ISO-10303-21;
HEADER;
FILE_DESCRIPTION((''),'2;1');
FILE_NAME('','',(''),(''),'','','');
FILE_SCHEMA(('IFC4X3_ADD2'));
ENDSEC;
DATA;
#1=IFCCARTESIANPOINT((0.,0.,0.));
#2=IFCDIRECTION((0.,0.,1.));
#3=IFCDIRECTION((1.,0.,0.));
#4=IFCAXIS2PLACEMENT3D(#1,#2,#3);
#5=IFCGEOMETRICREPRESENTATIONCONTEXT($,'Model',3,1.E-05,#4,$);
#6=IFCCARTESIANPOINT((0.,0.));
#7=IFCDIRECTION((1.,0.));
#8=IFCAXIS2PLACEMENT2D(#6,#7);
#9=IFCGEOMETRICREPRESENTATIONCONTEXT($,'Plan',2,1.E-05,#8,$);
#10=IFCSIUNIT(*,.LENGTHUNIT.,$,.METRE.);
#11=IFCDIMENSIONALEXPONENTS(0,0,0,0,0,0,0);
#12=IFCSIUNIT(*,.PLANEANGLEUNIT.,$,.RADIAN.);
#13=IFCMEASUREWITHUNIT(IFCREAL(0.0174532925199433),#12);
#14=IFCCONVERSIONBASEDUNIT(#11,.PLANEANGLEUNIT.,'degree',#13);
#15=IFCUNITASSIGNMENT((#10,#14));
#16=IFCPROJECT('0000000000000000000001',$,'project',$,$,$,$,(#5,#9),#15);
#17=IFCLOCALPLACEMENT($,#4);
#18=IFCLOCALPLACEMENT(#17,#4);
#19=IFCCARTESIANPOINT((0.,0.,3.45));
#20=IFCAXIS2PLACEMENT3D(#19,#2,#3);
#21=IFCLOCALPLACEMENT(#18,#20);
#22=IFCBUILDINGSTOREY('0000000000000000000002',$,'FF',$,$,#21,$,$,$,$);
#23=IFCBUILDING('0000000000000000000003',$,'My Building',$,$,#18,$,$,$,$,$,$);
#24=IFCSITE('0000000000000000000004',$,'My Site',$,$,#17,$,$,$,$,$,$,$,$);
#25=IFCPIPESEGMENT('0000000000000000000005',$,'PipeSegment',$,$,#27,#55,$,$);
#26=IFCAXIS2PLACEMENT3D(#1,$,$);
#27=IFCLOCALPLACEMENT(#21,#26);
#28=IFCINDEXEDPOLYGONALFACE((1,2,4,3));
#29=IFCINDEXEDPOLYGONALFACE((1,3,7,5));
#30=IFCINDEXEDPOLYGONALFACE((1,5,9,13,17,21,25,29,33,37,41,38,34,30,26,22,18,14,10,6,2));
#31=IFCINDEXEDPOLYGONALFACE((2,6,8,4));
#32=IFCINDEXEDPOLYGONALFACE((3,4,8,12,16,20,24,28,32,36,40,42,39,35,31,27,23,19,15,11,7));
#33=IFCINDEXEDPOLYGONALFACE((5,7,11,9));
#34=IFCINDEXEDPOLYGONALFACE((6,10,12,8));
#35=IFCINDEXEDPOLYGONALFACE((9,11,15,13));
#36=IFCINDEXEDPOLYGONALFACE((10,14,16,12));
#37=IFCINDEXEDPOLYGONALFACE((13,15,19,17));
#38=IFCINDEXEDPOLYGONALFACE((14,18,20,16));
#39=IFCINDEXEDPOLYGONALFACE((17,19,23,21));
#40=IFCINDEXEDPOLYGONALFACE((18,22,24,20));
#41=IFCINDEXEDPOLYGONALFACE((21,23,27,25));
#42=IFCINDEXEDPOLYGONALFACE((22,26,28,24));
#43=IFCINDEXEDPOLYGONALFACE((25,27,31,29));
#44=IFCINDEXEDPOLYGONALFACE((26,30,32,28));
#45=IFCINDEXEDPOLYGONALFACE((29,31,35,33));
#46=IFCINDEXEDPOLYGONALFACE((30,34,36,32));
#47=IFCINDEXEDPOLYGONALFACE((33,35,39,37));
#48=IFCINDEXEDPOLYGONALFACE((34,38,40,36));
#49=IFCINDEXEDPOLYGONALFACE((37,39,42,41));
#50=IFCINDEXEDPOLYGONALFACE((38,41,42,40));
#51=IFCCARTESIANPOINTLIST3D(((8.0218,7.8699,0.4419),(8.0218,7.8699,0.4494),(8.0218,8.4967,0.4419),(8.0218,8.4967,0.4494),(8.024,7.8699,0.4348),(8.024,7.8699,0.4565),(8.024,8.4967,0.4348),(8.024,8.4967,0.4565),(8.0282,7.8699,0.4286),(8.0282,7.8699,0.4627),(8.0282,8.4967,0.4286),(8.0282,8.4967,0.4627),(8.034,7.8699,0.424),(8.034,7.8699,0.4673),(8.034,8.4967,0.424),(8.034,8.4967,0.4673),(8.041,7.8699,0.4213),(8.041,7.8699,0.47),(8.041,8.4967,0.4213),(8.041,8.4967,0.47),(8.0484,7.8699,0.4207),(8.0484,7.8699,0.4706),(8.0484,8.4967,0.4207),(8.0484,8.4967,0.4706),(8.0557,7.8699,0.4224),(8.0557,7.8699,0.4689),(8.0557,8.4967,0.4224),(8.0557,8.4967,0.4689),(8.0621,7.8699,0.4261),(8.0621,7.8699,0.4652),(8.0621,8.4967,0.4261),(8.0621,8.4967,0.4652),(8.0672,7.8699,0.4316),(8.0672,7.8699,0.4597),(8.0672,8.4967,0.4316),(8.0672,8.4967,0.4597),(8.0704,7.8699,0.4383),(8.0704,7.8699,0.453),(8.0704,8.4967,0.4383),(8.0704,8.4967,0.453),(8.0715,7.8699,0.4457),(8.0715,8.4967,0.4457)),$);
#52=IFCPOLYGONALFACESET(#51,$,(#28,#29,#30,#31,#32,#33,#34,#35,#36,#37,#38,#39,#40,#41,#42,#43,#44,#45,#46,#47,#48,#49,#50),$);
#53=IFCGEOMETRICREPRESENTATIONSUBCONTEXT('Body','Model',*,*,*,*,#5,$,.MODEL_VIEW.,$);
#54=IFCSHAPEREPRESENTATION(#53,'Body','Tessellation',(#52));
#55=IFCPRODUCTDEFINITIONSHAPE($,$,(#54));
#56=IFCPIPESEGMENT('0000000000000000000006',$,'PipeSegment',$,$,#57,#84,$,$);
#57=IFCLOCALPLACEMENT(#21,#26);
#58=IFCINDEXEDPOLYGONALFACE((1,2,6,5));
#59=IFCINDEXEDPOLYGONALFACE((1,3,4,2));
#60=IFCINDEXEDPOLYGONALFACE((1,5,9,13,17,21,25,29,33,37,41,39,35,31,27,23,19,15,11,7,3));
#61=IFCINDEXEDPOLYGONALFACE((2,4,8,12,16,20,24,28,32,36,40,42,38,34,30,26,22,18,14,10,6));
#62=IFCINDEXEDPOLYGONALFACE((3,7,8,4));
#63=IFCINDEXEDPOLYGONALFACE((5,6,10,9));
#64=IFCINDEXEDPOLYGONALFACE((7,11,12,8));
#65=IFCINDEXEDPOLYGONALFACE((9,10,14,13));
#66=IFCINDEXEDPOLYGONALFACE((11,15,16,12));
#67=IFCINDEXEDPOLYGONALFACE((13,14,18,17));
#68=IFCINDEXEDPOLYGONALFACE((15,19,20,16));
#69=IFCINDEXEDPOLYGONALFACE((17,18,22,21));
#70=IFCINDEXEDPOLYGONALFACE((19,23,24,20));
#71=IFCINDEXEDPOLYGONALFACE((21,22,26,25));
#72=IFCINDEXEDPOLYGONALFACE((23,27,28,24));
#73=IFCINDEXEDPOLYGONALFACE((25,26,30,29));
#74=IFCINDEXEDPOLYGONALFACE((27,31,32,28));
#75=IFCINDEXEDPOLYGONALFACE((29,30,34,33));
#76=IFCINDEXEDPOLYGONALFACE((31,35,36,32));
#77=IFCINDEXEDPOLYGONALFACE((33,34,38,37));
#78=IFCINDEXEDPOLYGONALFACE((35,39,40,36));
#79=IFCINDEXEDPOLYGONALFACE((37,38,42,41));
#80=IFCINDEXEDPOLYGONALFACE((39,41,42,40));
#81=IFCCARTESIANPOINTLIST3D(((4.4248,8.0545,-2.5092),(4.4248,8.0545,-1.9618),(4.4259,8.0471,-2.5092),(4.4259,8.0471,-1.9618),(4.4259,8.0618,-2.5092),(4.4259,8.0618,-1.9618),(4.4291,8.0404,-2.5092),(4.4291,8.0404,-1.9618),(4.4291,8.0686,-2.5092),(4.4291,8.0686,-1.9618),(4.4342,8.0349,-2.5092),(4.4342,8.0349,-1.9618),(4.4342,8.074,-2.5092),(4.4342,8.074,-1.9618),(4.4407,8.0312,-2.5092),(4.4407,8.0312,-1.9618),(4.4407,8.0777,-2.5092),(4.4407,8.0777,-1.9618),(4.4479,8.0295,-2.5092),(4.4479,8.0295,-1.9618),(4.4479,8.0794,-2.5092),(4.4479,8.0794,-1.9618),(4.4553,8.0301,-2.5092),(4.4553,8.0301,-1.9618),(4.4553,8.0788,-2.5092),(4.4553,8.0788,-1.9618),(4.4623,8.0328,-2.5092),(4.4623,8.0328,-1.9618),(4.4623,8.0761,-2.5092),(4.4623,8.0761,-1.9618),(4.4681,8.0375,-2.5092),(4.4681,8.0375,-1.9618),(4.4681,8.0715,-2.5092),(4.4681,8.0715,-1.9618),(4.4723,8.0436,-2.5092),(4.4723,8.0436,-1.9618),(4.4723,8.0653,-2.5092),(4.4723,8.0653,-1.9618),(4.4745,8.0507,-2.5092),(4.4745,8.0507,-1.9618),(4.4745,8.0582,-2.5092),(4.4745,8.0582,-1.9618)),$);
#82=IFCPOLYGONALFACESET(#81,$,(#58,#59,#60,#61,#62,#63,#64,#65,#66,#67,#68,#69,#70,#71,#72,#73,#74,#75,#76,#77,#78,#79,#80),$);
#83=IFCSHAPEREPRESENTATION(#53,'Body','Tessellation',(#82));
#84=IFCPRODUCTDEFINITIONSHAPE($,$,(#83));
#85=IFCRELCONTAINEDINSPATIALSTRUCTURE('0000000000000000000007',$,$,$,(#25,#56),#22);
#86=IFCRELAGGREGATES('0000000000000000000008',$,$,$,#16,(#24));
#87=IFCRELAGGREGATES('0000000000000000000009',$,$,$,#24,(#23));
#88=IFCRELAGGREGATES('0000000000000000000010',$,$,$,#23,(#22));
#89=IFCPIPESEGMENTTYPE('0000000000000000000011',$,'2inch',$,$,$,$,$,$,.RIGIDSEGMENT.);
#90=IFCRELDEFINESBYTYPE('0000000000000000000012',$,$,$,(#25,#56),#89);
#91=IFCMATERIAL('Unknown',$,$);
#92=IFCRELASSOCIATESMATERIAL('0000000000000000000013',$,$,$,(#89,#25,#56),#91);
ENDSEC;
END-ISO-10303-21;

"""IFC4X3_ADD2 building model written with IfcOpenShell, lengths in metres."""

from ifc_helpers import new_model, entity, si_unit, converted_unit, frame, origin_with_axes, origin_2d_with_axis, place, context, subcontext, project, spatial, circle, extrude, material, material_profile, profile_set, profile_usage, type_object, element, save


model = new_model("IFC4X3_ADD2")

# Units and contexts
model_context = context("Model", 3, precision=1e-05, world=origin_with_axes())
plan_context = context("Plan", 2, precision=1e-05, world=origin_2d_with_axis())
body_context_1 = subcontext(model_context, "Body", "Model", "MODEL_VIEW")
ifc_project = project(units=[si_unit("LENGTHUNIT", "METRE"), converted_unit("PLANEANGLEUNIT", "degree", entity("IfcReal", 0.0174532925199433), si_unit("PLANEANGLEUNIT", "RADIAN"), dimensions=[0, 0, 0, 0, 0, 0, 0])], contexts=[model_context, plan_context])

# Site, building, storey
site_placement = place(None, origin_with_axes())
site = spatial("IfcSite", under=ifc_project, at=site_placement, Name="My Site")
building_placement = place(site_placement, origin_with_axes())
building = spatial("IfcBuilding", under=site, at=building_placement, Name="My Building")
storey_placement = place(building_placement, frame((0.0, 0.0, 3.45), z_axis=(0.0, 0.0, 1.0), x_axis=(1.0, 0.0, 0.0)))
storey = spatial("IfcBuildingStorey", under=building, at=storey_placement, Name="FF")

# Shared definitions
ifc_material_1 = material(Name="Unknown")

# Pipe segments
ifc_material_profile_1 = material_profile(ifc_material_1, circle(Radius=0.025))
ifc_profile_set_1 = profile_set([ifc_material_profile_1])
pipe_segment_type_1 = type_object("IfcPipeSegmentType", Name="2inch", PredefinedType="RIGIDSEGMENT", material=ifc_profile_set_1)
ifc_profile_usage_1 = profile_usage(ifc_profile_set_1)
pipe_segment_1_placement = place(storey_placement, frame((8.0465, 8.4967, 0.4457), z_axis=(0.0, -1.0, 0.0), x_axis=(1.0, 0.0, 0.0)))
element("IfcPipeSegment", 1, at=pipe_segment_1_placement, inside=storey, type_object=pipe_segment_type_1, material=ifc_profile_usage_1, Name="PipeSegment", context=body_context_1, shape_type="SweptSolid", body=[
    extrude(circle(Radius=0.025), origin_with_axes(), (0.0, 0.0, 1.0), 0.6268),
])
ifc_profile_usage_2 = profile_usage(ifc_profile_set_1)
pipe_segment_2_placement = place(storey_placement, frame((4.4498, 8.0545, -2.5092), z_axis=(0.0, 0.0, 1.0), x_axis=(-1.0, 0.0, 0.0)))
element("IfcPipeSegment", 2, at=pipe_segment_2_placement, inside=storey, type_object=pipe_segment_type_1, material=ifc_profile_usage_2, Name="PipeSegment", context=body_context_1, shape_type="SweptSolid", body=[
    extrude(circle(Radius=0.025), origin_with_axes(), (0.0, 0.0, 1.0), 0.5474),
])

save(model, "model.ifc")
